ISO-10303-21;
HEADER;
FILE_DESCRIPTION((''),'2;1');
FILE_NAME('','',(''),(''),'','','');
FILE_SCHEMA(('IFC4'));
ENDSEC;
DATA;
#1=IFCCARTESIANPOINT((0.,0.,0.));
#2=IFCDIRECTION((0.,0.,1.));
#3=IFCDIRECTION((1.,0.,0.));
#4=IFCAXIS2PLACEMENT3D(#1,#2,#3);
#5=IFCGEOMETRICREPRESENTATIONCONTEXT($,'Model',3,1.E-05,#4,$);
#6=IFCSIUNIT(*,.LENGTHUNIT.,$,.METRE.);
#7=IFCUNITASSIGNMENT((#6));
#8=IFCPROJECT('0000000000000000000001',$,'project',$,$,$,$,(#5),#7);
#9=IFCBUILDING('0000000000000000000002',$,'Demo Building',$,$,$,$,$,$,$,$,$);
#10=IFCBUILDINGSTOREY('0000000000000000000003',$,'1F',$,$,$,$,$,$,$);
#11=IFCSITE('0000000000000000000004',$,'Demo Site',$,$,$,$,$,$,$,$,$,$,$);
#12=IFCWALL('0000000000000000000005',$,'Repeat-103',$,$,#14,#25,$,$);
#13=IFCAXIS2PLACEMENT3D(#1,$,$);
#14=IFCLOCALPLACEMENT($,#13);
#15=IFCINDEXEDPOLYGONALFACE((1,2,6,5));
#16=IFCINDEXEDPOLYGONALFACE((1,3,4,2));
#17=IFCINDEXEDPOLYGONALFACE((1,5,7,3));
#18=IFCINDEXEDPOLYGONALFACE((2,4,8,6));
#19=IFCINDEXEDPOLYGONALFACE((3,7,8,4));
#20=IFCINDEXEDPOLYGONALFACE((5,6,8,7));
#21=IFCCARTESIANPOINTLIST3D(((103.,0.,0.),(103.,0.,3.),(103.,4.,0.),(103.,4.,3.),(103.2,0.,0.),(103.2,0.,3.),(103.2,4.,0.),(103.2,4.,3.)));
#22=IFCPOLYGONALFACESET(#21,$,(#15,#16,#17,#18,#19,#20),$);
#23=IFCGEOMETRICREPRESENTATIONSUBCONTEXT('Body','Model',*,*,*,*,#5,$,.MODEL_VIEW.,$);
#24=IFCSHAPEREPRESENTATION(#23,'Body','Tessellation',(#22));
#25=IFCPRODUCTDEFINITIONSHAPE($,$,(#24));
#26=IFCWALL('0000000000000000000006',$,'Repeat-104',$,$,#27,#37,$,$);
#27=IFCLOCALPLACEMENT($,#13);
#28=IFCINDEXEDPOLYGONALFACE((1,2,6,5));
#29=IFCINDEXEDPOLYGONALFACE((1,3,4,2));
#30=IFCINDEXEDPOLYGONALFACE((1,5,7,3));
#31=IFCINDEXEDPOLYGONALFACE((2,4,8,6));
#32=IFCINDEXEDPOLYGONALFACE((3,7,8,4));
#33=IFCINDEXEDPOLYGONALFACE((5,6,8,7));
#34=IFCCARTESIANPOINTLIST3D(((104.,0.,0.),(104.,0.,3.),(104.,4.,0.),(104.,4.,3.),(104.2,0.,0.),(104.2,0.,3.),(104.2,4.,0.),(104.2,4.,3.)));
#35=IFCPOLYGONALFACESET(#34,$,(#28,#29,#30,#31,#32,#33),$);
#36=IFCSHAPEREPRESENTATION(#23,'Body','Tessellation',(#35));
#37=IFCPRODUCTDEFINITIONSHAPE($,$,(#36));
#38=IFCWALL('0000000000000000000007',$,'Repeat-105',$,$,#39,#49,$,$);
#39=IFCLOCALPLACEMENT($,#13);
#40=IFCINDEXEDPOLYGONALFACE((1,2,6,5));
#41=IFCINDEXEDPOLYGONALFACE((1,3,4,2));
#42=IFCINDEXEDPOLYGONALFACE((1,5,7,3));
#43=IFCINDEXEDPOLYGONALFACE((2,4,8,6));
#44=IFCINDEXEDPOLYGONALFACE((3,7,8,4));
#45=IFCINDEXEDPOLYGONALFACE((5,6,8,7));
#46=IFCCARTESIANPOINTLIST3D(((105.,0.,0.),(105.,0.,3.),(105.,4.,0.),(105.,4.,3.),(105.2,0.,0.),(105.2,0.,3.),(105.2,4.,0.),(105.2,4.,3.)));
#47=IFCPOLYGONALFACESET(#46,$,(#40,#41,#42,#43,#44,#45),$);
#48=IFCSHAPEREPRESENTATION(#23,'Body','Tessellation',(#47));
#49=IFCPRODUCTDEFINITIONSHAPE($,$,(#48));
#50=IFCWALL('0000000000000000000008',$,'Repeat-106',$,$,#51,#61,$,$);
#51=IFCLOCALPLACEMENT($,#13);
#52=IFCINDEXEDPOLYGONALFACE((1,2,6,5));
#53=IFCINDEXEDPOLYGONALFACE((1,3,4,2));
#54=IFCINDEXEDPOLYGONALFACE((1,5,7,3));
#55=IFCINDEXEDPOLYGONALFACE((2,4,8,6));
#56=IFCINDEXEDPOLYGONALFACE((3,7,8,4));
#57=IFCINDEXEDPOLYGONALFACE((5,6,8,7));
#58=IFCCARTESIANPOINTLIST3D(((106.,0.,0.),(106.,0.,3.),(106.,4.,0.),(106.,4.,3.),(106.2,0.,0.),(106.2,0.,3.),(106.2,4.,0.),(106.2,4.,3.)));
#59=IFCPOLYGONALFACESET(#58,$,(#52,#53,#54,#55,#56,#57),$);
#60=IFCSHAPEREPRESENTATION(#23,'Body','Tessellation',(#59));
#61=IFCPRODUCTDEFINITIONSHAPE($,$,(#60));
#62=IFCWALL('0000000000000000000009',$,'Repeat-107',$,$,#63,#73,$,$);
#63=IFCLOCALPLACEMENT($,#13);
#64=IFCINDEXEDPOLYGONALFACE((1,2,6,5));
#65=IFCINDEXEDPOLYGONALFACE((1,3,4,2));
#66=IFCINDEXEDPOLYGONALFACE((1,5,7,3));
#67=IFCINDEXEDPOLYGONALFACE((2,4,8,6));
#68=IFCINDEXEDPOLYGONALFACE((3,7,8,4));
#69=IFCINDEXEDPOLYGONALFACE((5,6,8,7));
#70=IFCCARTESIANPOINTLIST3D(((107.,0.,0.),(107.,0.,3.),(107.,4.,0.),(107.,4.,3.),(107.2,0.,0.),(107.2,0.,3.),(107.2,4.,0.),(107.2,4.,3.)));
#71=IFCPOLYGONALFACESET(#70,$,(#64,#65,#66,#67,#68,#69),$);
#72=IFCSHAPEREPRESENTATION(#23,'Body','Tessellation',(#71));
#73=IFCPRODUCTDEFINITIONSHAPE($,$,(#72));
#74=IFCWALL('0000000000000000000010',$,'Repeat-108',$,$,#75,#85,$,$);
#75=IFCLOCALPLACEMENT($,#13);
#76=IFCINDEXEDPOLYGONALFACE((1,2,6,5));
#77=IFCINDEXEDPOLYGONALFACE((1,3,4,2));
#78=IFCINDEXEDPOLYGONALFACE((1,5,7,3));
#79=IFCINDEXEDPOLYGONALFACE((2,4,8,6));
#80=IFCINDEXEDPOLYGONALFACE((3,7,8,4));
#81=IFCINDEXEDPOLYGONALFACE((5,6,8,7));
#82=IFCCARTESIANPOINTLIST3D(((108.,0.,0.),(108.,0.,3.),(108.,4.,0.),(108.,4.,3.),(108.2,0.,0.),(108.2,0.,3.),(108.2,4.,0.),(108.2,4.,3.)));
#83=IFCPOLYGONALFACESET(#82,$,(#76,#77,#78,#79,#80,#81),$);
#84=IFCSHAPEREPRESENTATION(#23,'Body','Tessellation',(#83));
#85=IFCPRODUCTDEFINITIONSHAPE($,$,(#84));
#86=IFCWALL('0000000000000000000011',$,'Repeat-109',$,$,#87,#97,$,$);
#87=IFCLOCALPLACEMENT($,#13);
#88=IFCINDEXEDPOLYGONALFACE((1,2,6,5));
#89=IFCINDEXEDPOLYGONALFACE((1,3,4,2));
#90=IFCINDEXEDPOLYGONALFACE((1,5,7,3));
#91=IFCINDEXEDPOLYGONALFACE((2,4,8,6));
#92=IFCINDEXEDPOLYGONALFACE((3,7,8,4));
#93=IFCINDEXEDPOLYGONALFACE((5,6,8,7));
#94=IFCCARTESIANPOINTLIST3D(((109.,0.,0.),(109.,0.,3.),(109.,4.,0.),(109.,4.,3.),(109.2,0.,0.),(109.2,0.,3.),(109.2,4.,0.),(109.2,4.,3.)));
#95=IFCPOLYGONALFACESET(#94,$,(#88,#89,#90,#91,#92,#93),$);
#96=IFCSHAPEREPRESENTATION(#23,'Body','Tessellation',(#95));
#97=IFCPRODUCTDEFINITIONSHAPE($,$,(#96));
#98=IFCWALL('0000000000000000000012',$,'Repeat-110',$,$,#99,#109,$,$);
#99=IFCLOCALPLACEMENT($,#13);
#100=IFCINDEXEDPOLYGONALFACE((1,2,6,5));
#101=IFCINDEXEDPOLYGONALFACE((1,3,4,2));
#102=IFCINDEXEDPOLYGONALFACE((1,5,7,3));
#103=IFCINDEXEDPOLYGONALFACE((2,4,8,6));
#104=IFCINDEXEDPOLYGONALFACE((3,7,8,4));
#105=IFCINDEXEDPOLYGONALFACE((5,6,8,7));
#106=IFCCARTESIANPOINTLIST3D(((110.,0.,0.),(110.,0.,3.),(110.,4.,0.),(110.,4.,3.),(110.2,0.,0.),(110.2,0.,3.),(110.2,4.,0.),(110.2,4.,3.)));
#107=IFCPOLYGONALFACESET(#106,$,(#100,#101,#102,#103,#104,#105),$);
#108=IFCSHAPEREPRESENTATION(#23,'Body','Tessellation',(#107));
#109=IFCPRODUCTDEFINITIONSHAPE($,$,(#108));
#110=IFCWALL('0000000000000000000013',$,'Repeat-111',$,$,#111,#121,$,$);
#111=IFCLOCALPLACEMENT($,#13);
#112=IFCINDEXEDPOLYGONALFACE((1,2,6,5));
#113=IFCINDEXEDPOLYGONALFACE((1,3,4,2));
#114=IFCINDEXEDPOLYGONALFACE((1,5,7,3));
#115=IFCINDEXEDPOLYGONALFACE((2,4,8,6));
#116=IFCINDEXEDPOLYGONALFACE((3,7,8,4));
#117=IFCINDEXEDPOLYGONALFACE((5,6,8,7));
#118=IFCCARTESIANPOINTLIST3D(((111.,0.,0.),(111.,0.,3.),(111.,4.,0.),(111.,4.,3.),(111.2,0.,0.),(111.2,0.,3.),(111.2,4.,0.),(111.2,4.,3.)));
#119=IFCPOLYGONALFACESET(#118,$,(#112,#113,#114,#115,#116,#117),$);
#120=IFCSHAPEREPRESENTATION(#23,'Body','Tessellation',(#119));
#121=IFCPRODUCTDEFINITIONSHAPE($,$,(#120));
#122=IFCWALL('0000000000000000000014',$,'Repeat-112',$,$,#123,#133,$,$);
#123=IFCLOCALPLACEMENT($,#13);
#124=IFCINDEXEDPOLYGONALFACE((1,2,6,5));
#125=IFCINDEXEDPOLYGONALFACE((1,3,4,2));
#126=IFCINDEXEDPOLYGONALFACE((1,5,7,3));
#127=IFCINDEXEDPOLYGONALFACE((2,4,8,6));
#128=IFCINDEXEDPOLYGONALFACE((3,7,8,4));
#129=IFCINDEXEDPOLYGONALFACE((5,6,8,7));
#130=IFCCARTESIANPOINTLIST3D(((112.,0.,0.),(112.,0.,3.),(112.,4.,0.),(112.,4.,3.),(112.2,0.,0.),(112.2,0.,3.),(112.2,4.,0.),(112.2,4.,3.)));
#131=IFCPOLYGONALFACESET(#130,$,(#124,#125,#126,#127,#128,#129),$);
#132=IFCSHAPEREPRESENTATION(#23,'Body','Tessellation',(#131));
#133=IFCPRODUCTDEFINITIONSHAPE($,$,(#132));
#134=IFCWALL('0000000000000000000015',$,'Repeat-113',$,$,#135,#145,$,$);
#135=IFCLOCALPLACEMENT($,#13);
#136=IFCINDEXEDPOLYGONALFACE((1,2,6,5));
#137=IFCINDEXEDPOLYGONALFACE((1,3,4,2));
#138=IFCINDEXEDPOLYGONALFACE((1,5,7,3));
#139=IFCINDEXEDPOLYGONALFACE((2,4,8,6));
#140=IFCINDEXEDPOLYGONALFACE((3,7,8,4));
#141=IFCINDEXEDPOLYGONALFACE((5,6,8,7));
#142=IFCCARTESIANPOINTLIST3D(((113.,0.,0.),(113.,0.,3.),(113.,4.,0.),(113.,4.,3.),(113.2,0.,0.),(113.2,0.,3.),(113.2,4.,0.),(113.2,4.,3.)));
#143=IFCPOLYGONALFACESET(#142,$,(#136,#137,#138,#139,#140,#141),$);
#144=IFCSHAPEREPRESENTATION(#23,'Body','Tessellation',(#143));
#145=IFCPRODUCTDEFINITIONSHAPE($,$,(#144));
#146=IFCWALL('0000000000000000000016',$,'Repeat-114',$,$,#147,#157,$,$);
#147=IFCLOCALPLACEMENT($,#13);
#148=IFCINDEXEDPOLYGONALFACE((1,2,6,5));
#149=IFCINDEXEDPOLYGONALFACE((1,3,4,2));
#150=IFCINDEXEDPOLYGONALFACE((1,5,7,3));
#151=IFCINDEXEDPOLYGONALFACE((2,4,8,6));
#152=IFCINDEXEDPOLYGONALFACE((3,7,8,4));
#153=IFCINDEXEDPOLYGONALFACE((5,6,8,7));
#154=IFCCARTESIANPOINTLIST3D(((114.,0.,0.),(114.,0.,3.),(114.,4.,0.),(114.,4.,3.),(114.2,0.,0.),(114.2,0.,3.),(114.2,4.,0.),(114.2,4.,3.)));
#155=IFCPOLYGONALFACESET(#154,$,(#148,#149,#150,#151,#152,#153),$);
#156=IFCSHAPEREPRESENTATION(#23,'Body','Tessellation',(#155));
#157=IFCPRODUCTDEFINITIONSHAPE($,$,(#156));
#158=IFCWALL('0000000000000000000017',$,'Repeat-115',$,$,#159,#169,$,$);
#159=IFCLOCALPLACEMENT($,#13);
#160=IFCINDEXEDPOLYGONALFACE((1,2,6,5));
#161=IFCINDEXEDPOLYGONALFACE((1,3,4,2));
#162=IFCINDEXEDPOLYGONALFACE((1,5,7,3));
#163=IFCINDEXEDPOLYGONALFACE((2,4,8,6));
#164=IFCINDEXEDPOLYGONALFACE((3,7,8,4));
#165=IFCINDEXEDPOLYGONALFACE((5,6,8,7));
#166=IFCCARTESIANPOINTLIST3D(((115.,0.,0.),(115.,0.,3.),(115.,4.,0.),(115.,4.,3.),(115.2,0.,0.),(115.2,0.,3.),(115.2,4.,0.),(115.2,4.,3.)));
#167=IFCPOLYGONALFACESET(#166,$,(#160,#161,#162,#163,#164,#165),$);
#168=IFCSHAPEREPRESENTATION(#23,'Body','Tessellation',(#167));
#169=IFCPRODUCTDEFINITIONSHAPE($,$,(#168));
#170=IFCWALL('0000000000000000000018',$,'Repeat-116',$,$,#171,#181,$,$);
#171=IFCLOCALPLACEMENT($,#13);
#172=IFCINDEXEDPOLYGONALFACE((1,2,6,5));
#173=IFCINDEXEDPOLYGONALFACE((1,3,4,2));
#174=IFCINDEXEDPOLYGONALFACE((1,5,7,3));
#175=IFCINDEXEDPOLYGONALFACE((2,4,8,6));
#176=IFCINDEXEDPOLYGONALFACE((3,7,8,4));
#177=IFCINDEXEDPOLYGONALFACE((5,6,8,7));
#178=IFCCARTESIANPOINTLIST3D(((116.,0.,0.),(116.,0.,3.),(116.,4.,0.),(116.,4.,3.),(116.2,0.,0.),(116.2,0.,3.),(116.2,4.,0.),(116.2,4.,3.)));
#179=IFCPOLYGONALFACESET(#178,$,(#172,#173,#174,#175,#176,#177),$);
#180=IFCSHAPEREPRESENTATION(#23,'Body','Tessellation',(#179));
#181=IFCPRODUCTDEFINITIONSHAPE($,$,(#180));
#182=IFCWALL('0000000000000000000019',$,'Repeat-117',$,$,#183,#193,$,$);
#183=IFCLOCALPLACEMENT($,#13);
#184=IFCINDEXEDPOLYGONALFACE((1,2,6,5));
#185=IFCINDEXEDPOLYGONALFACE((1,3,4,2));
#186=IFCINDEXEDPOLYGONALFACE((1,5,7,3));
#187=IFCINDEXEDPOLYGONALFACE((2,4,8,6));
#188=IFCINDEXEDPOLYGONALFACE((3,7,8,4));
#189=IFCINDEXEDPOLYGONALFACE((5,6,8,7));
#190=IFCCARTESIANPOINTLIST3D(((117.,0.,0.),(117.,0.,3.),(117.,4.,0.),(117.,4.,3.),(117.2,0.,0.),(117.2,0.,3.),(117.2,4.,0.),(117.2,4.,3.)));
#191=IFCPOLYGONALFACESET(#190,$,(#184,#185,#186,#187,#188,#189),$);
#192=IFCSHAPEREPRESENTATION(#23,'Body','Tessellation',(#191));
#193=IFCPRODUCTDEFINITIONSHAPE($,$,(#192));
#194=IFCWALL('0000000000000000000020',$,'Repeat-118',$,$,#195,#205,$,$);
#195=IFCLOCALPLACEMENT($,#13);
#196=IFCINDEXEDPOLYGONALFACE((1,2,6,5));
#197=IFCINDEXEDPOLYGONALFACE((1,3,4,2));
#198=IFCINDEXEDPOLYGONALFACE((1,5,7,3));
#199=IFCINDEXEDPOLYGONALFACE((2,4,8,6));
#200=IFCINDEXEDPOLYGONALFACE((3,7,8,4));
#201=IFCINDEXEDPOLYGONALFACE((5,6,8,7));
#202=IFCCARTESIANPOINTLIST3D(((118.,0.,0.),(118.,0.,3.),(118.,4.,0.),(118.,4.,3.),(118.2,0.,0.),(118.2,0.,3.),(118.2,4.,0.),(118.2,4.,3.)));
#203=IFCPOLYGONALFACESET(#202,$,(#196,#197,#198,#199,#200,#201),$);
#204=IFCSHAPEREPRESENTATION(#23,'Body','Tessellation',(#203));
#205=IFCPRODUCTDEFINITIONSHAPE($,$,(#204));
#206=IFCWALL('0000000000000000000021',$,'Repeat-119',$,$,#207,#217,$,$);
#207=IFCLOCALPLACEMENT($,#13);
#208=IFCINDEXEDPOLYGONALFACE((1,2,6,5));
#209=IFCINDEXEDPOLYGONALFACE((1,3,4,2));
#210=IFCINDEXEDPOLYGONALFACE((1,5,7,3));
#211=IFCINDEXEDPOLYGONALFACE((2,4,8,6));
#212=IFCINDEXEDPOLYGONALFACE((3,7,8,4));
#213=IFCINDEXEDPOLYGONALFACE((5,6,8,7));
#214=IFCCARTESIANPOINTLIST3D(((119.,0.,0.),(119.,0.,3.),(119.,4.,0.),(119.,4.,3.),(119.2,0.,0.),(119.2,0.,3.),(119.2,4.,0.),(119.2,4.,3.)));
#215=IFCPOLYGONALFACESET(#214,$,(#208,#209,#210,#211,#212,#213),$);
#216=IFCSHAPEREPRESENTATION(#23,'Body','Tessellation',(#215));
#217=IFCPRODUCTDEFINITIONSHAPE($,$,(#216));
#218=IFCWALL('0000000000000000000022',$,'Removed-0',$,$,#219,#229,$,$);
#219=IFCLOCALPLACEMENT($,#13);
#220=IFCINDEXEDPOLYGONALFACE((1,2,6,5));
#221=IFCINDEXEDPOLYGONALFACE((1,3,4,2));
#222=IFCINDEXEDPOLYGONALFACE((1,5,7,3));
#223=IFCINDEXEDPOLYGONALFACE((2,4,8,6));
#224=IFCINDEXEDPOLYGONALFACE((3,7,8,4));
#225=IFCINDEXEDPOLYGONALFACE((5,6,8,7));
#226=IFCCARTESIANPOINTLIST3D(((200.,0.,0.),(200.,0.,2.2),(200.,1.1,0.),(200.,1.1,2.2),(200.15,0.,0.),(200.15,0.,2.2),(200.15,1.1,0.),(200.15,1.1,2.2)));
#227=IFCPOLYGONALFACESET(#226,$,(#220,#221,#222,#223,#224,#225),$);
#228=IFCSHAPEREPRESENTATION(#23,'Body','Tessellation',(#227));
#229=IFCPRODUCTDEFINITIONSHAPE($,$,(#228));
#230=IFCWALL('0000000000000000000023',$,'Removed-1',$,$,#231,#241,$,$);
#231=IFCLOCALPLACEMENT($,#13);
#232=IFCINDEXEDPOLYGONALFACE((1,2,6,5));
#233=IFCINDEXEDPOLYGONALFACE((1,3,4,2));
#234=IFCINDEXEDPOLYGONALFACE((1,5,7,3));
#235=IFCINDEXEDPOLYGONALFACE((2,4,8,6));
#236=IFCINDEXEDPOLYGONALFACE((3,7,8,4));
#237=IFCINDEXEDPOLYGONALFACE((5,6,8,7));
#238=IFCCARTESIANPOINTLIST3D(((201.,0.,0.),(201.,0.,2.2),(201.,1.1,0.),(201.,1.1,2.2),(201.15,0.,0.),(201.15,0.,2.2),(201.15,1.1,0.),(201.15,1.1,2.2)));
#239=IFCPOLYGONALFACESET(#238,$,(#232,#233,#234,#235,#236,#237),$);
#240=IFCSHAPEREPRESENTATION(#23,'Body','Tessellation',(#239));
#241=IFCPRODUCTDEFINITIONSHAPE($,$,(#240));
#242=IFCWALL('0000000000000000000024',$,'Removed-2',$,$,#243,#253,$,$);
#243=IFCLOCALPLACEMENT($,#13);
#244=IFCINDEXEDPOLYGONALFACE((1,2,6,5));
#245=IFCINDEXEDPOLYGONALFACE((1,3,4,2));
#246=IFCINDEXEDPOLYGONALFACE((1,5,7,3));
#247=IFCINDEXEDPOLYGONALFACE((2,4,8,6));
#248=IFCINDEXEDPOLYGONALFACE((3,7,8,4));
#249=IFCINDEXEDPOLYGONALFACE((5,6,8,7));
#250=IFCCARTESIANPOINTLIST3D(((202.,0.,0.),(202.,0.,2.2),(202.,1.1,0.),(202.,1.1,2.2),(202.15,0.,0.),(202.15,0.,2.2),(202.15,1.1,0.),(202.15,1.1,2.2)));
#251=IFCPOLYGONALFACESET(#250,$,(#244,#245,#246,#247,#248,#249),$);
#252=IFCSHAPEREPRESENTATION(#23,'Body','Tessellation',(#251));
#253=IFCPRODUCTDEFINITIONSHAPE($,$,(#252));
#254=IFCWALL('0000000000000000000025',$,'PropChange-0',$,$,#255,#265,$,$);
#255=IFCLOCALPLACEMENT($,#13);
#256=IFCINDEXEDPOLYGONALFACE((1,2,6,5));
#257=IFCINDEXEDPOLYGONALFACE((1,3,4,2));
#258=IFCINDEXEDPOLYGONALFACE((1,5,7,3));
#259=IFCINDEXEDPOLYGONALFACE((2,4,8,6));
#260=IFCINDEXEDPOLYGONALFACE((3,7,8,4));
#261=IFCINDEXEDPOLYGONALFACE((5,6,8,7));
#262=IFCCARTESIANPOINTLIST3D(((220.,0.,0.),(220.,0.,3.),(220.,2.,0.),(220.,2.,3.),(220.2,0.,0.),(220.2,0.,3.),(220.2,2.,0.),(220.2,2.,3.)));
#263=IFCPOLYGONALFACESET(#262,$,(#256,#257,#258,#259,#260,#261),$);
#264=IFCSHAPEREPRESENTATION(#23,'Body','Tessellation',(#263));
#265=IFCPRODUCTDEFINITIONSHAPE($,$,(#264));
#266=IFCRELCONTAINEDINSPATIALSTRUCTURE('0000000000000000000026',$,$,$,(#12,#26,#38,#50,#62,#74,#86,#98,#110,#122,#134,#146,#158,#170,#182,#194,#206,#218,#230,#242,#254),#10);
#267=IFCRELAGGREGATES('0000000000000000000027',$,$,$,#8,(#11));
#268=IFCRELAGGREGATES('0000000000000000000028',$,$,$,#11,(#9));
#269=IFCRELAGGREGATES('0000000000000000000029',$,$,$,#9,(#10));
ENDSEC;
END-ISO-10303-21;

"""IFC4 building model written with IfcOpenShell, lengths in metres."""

from ifc_helpers import new_model, entity, si_unit, frame, origin_with_axes, place, context, subcontext, project, spatial, element, save


model = new_model("IFC4")

# Units and contexts
model_context = context("Model", 3, precision=1e-05, world=origin_with_axes())
body_context = subcontext(model_context, "Body", "Model", "MODEL_VIEW")
ifc_project = project(units=[si_unit("LENGTHUNIT", "METRE")], contexts=[model_context])

# Site, building, storey
site = spatial("IfcSite", under=ifc_project, Name="Demo Site")
building = spatial("IfcBuilding", under=site, Name="Demo Building")
storey = spatial("IfcBuildingStorey", under=building, Name="1F")

# Walls
for number, where, z_axis, x_axis, name in (
    (1, (103.0, 0.0, 0.0), (0.0, 0.0, 1.0), (1.0, 0.0, 0.0), "Repeat-103"),
    (2, (104.0, 0.0, 0.0), (0.0, 0.0, 1.0), (1.0, 0.0, 0.0), "Repeat-104"),
    (3, (105.0, 0.0, 0.0), (0.0, 0.0, 1.0), (1.0, 0.0, 0.0), "Repeat-105"),
    (4, (106.0, 0.0, 0.0), (0.0, 0.0, 1.0), (1.0, 0.0, 0.0), "Repeat-106"),
    (5, (107.0, 0.0, 0.0), (0.0, 0.0, 1.0), (1.0, 0.0, 0.0), "Repeat-107"),
    (6, (108.0, 0.0, 0.0), (0.0, 0.0, 1.0), (1.0, 0.0, 0.0), "Repeat-108"),
    (7, (109.0, 0.0, 0.0), (0.0, 0.0, 1.0), (1.0, 0.0, 0.0), "Repeat-109"),
    (8, (110.0, 0.0, 0.0), (0.0, 0.0, 1.0), (1.0, 0.0, 0.0), "Repeat-110"),
    (9, (111.0, 0.0, 0.0), (0.0, 0.0, 1.0), (1.0, 0.0, 0.0), "Repeat-111"),
    (10, (112.0, 0.0, 0.0), (0.0, 0.0, 1.0), (1.0, 0.0, 0.0), "Repeat-112"),
    (11, (113.0, 0.0, 0.0), (0.0, 0.0, 1.0), (1.0, 0.0, 0.0), "Repeat-113"),
    (12, (114.0, 0.0, 0.0), (0.0, 0.0, 1.0), (1.0, 0.0, 0.0), "Repeat-114"),
    (13, (115.0, 0.0, 0.0), (0.0, 0.0, 1.0), (1.0, 0.0, 0.0), "Repeat-115"),
    (14, (116.0, 0.0, 0.0), (0.0, 0.0, 1.0), (1.0, 0.0, 0.0), "Repeat-116"),
    (15, (117.0, 0.0, 0.0), (0.0, 0.0, 1.0), (1.0, 0.0, 0.0), "Repeat-117"),
    (16, (118.0, 0.0, 0.0), (0.0, 0.0, 1.0), (1.0, 0.0, 0.0), "Repeat-118"),
    (17, (119.0, 0.0, 0.0), (0.0, 0.0, 1.0), (1.0, 0.0, 0.0), "Repeat-119"),
):
    element("IfcWall", number, at=place(None, frame(where, z_axis=z_axis, x_axis=x_axis)), inside=storey, Name=name, context=body_context, shape_type="CSG", body=[
        entity("IfcBlock", entity("IfcAxis2Placement3D", entity("IfcCartesianPoint", [0.0, 0.0, 0.0]), entity("IfcDirection", [0.0, 0.0, 1.0]), entity("IfcDirection", [1.0, 0.0, 0.0])), 0.2, 4.0, 3.0),
    ])
for number, where, z_axis, x_axis, name in (
    (18, (200.0, 0.0, 0.0), (0.0, 0.0, 1.0), (1.0, 0.0, 0.0), "Removed-0"),
    (19, (201.0, 0.0, 0.0), (0.0, 0.0, 1.0), (1.0, 0.0, 0.0), "Removed-1"),
    (20, (202.0, 0.0, 0.0), (0.0, 0.0, 1.0), (1.0, 0.0, 0.0), "Removed-2"),
):
    element("IfcWall", number, at=place(None, frame(where, z_axis=z_axis, x_axis=x_axis)), inside=storey, Name=name, context=body_context, shape_type="CSG", body=[
        entity("IfcBlock", entity("IfcAxis2Placement3D", entity("IfcCartesianPoint", [0.0, 0.0, 0.0]), entity("IfcDirection", [0.0, 0.0, 1.0]), entity("IfcDirection", [1.0, 0.0, 0.0])), 0.15, 1.1, 2.2),
    ])
for number, where, z_axis, x_axis, name in (
    (21, (220.0, 0.0, 0.0), (0.0, 0.0, 1.0), (1.0, 0.0, 0.0), "PropChange-0"),
):
    element("IfcWall", number, at=place(None, frame(where, z_axis=z_axis, x_axis=x_axis)), inside=storey, Name=name, context=body_context, shape_type="CSG", body=[
        entity("IfcBlock", entity("IfcAxis2Placement3D", entity("IfcCartesianPoint", [0.0, 0.0, 0.0]), entity("IfcDirection", [0.0, 0.0, 1.0]), entity("IfcDirection", [1.0, 0.0, 0.0])), 0.2, 2.0, 3.0),
    ])

save(model, "model.ifc")
